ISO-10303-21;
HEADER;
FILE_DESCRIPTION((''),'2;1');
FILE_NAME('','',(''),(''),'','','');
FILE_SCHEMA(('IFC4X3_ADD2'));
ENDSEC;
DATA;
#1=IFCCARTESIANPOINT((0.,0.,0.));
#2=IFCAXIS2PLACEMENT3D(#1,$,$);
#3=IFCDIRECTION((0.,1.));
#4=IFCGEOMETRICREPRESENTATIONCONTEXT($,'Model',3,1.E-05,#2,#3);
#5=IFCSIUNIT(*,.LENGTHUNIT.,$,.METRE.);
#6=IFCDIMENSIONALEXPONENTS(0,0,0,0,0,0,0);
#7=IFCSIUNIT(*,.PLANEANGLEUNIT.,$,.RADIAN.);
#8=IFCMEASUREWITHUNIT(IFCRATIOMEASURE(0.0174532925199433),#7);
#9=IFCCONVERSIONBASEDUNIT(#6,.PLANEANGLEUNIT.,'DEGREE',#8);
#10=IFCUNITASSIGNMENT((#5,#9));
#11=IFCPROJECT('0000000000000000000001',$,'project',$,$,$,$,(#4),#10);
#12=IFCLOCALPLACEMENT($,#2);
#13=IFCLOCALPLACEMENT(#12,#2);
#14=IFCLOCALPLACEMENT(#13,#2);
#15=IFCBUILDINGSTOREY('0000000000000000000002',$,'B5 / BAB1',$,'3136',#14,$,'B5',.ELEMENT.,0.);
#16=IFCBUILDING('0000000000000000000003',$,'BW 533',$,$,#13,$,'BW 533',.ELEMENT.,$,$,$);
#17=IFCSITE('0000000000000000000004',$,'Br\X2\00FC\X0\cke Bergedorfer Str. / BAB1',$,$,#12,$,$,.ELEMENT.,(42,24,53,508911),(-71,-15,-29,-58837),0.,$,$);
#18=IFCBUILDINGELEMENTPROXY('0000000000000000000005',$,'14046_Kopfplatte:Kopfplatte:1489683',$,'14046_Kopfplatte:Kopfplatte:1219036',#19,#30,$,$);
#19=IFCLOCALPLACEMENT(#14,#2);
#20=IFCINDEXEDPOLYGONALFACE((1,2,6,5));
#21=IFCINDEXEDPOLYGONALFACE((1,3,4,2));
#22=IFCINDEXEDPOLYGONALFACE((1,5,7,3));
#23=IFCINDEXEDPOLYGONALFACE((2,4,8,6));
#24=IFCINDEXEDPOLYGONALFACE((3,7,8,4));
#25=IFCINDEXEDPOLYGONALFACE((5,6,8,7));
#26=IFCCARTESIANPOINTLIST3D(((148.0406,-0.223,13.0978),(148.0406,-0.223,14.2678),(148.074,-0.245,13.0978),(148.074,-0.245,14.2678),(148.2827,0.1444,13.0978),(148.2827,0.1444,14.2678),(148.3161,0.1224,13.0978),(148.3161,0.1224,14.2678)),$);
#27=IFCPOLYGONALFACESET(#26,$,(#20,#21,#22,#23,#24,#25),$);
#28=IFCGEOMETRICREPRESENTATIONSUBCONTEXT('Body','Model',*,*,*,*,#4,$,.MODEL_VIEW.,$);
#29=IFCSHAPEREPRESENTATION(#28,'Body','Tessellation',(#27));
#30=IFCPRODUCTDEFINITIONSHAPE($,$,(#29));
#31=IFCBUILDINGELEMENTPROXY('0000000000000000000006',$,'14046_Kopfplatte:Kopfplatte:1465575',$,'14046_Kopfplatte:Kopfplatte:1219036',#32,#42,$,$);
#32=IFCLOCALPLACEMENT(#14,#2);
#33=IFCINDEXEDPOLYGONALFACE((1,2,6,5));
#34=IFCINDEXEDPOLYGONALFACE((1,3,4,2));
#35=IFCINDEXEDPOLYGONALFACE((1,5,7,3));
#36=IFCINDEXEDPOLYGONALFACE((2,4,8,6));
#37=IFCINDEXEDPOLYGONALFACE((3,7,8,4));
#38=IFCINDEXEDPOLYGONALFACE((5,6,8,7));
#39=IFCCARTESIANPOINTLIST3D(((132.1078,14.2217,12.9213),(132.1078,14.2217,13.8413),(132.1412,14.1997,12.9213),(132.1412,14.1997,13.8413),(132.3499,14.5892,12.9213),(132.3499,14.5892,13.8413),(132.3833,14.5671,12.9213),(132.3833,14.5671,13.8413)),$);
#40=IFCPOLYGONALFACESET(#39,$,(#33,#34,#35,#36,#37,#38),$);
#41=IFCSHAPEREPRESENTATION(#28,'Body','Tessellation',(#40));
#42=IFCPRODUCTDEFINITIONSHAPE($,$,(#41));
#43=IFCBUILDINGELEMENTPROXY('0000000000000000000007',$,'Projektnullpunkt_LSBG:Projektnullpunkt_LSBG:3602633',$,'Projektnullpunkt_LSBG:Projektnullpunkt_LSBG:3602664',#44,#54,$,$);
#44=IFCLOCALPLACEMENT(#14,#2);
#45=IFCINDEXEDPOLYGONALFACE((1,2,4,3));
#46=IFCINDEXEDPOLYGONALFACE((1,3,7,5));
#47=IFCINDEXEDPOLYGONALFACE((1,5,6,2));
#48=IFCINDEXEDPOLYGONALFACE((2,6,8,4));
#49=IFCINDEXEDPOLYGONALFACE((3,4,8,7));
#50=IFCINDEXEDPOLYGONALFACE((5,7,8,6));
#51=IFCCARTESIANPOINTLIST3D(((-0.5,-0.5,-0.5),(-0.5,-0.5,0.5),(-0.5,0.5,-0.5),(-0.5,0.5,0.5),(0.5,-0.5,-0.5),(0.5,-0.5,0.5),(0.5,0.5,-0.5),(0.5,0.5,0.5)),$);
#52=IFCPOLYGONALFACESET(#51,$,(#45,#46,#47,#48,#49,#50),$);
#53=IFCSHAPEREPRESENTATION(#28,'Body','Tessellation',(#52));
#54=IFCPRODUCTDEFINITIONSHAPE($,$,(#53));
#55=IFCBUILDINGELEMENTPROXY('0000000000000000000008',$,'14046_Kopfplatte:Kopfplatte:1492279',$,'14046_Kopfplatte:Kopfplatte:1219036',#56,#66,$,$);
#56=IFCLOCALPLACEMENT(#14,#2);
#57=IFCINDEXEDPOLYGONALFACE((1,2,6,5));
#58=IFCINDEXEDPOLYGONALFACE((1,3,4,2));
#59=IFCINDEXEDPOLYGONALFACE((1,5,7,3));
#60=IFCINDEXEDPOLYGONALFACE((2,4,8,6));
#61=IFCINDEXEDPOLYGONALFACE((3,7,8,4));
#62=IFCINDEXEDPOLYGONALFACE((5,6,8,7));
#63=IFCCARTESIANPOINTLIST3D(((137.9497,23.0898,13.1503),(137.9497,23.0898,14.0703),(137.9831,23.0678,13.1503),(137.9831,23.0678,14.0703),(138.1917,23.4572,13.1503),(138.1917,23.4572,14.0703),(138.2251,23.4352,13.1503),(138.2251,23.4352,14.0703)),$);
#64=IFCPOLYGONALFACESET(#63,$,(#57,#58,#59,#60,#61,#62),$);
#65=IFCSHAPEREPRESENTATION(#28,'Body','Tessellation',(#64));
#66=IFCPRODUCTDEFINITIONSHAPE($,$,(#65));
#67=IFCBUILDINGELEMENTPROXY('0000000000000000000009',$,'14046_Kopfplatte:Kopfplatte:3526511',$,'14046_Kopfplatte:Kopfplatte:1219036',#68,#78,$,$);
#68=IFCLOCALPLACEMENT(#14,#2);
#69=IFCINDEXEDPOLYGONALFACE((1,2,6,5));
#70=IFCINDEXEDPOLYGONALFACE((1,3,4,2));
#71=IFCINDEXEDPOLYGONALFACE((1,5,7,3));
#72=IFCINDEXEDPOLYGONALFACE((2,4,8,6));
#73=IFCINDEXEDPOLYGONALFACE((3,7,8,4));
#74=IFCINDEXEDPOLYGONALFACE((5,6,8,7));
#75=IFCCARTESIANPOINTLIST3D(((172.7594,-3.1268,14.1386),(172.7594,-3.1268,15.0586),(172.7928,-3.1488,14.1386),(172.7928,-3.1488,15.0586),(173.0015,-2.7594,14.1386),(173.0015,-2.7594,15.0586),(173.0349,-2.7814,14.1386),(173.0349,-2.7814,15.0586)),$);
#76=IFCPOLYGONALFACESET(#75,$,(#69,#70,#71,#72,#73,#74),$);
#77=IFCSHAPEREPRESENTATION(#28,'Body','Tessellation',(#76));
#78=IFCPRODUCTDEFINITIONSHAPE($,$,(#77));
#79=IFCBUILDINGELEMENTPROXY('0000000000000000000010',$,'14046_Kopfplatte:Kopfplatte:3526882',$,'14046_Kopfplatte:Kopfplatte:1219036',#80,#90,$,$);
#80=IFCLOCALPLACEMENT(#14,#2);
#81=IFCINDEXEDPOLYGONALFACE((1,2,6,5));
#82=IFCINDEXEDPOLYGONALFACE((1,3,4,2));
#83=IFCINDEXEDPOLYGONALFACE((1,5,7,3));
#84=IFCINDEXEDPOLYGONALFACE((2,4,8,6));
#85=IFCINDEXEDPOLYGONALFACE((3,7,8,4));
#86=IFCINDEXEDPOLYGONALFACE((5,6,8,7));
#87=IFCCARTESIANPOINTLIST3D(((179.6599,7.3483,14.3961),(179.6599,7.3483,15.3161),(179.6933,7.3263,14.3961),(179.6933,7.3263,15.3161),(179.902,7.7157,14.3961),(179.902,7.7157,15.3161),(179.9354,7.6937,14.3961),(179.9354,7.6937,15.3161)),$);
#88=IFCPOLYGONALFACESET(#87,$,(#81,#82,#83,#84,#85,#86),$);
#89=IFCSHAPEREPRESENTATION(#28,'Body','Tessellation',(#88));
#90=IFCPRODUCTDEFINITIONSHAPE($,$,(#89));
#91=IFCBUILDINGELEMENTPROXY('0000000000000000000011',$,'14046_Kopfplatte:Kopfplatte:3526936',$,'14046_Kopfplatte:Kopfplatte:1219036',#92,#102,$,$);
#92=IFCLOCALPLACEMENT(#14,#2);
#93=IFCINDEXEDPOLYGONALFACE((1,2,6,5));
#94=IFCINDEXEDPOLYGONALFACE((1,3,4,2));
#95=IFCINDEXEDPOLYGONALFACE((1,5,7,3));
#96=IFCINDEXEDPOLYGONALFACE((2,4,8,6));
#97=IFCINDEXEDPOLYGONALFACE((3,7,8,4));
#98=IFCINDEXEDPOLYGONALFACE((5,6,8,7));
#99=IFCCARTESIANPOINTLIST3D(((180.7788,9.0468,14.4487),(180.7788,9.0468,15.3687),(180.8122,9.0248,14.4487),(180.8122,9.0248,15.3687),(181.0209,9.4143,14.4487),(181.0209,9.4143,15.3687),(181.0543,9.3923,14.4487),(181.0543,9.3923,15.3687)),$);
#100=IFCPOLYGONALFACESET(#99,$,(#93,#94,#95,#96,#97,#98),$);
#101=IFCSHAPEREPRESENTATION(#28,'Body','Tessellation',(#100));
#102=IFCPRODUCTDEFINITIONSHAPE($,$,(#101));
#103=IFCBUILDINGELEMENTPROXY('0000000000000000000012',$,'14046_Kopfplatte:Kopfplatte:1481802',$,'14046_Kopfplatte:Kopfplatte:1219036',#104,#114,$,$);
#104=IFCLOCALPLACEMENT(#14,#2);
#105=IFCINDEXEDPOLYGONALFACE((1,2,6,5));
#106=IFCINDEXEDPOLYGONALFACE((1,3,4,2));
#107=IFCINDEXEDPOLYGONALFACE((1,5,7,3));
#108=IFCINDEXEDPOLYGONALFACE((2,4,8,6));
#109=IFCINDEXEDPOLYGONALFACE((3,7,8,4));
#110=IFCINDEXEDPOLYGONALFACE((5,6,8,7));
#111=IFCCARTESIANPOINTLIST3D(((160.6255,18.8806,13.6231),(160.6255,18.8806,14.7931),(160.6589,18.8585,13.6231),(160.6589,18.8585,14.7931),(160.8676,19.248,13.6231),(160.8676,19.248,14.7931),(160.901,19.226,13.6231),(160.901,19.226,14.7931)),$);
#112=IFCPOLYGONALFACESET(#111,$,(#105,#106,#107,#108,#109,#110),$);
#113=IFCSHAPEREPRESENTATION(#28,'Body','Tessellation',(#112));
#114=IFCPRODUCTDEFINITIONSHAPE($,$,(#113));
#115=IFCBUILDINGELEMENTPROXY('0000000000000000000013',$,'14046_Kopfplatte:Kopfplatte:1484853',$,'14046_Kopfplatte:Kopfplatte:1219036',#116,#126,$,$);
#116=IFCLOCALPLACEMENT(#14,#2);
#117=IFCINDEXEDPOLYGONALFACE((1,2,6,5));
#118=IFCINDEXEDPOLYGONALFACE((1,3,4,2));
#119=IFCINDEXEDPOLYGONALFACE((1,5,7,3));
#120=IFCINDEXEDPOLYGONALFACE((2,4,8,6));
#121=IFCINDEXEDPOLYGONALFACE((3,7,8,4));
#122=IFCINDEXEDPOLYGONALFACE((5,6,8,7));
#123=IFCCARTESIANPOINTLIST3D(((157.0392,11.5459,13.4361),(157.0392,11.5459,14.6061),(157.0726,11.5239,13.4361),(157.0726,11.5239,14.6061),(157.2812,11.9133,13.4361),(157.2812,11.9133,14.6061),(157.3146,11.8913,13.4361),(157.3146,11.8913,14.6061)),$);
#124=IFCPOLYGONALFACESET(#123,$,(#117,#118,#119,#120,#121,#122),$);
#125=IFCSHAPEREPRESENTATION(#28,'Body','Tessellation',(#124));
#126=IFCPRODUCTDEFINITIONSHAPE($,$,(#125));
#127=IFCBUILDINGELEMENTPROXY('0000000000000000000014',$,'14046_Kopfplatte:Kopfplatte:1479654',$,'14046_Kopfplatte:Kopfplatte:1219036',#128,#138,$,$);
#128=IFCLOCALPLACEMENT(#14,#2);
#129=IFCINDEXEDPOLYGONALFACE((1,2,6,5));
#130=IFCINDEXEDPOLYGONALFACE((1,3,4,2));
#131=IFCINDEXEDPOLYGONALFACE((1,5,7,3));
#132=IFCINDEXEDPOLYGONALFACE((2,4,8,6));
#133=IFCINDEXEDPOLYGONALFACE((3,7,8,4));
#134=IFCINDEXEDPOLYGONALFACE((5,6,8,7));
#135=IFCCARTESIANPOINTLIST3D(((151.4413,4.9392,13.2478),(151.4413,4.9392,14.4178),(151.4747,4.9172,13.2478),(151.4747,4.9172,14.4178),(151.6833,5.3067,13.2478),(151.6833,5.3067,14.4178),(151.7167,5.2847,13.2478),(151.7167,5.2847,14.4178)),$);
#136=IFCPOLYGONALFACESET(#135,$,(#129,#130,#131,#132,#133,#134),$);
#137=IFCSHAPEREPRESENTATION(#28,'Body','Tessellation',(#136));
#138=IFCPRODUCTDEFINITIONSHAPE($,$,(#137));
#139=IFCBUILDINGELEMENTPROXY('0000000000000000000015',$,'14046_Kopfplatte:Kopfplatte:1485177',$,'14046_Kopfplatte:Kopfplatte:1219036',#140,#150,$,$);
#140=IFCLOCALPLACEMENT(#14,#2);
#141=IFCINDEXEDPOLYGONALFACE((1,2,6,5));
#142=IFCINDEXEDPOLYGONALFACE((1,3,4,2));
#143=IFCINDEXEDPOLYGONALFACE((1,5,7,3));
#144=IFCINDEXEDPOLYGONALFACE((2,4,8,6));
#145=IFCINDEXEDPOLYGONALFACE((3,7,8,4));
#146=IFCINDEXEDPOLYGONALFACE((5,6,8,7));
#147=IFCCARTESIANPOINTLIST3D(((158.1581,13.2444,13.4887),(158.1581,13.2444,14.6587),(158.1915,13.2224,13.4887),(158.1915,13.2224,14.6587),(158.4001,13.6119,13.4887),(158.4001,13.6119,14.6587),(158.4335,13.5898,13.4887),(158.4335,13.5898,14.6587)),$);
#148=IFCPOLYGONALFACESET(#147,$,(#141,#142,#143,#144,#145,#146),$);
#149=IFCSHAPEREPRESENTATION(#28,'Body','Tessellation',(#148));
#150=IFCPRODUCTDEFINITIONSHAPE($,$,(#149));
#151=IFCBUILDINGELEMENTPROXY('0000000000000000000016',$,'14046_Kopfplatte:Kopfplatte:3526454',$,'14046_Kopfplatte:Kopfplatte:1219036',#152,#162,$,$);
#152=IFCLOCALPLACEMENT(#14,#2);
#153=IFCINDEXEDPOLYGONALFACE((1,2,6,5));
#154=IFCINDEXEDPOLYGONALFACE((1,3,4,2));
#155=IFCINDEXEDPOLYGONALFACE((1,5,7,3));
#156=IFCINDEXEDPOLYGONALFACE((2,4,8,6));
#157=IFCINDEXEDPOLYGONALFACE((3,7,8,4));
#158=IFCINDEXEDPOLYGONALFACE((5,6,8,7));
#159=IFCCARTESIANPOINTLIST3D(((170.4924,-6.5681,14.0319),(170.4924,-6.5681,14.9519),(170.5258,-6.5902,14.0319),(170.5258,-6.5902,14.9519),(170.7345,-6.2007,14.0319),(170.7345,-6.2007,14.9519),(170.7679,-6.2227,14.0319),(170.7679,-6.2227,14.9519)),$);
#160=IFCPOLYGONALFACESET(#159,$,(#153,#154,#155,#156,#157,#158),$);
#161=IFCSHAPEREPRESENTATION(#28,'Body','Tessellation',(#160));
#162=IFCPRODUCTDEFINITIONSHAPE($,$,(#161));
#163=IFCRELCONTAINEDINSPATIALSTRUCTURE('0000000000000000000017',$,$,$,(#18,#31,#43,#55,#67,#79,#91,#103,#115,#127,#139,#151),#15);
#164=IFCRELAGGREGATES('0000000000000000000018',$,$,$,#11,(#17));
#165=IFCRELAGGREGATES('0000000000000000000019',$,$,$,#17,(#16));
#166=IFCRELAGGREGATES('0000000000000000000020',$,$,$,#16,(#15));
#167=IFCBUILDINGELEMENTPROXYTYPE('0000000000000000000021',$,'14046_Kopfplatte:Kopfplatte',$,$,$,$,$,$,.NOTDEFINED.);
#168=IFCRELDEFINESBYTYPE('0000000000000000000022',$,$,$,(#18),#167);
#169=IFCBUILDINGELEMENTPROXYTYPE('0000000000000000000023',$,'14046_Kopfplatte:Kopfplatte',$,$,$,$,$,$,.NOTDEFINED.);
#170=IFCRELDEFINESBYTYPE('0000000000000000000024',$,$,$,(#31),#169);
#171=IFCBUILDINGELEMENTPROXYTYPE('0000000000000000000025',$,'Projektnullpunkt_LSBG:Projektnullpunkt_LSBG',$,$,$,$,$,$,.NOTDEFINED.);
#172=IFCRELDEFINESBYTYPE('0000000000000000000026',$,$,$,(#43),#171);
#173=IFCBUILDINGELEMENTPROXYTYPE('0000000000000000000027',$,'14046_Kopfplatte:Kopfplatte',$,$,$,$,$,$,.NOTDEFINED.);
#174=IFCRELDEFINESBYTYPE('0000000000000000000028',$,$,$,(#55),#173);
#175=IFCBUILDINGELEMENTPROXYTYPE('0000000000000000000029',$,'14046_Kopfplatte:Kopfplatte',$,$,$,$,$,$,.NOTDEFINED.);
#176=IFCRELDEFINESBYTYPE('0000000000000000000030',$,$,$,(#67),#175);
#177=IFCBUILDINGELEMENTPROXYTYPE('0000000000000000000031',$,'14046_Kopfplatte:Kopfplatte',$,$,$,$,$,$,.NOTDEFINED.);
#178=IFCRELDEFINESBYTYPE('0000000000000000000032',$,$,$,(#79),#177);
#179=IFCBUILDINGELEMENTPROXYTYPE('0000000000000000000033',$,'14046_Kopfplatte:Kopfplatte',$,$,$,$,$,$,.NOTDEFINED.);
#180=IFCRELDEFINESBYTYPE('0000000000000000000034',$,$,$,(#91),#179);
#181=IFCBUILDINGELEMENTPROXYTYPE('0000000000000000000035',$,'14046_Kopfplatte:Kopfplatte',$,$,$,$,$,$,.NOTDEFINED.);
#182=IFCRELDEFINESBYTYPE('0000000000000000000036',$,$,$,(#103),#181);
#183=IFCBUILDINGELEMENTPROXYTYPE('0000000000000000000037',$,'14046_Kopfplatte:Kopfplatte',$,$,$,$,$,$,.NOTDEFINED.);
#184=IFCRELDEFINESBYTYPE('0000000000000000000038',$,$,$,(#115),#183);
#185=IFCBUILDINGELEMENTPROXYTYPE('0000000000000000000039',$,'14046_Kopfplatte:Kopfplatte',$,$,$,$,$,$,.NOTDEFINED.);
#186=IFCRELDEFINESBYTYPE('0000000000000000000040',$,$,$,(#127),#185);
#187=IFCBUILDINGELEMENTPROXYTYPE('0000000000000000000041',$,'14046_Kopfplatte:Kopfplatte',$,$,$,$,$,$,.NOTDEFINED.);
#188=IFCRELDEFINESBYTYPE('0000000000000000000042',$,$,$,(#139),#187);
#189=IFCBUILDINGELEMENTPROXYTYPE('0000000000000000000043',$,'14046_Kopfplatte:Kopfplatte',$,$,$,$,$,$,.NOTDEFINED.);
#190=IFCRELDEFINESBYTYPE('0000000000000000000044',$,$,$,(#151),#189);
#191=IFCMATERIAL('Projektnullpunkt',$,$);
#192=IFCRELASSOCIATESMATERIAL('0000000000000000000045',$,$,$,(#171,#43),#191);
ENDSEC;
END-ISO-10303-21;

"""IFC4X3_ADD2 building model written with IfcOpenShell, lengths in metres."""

from ifc_helpers import new_model, entity, si_unit, converted_unit, direction, frame, frame_2d, origin, origin_2d_with_axis, place, context, subcontext, project, spatial, rectangle, extrude, source, transform, mapped, material, type_object, type_shapes, element, save


model = new_model("IFC4X3_ADD2")

# Units and contexts
model_context = context("Model", 3, precision=1e-05, world=origin(), true_north=direction((0.0, 1.0)))
body_context = subcontext(model_context, "Body", "Model", "MODEL_VIEW")
ifc_project = project(units=[si_unit("LENGTHUNIT", "METRE"), converted_unit("PLANEANGLEUNIT", "DEGREE", entity("IfcRatioMeasure", 0.0174532925199433), si_unit("PLANEANGLEUNIT", "RADIAN"), dimensions=[0, 0, 0, 0, 0, 0, 0])], contexts=[model_context])

# Site, building, storey
site_placement = place(None, origin())
site = spatial("IfcSite", under=ifc_project, at=site_placement, Name="Brücke Bergedorfer Str. / BAB1", CompositionType="ELEMENT", RefLatitude=(42, 24, 53, 508911), RefLongitude=(-71, -15, -29, -58837), RefElevation=0.0)
building_placement = place(site_placement, origin())
building = spatial("IfcBuilding", under=site, at=building_placement, Name="BW 533", LongName="BW 533", CompositionType="ELEMENT")
storey_placement = place(building_placement, origin())
storey = spatial("IfcBuildingStorey", under=building, at=storey_placement, Name="B5 / BAB1", ObjectType="3136", LongName="B5", CompositionType="ELEMENT", Elevation=0.0)

# Building element proxies
building_element_proxy_type_1 = type_object("IfcBuildingElementProxyType", Name="14046_Kopfplatte:Kopfplatte", PredefinedType="NOTDEFINED")
shared_shape_1 = source(origin(), body_context, "Body", "SweptSolid", [
    extrude(rectangle(XDim=0.04, YDim=0.44, at=frame_2d((0.0, 0.0), x_axis=(1.0, 0.0))), frame((148.1784, -0.0503, 13.0978), z_axis=(0.0, 0.0, 1.0), x_axis=(0.835088, -0.550116, 0.0)), (0.0, 0.0, 1.0), 1.17),
])
type_shapes(building_element_proxy_type_1, [shared_shape_1])
proxy_1_placement = place(storey_placement, origin())
element("IfcBuildingElementProxy", 1, at=proxy_1_placement, inside=storey, type_object=building_element_proxy_type_1, Name="14046_Kopfplatte:Kopfplatte:1489683", ObjectType="14046_Kopfplatte:Kopfplatte:1219036", context=body_context, shape_type="MappedRepresentation", body=[
    mapped(shared_shape_1, transform((0.0, 0.0, 0.0), scale=1.0)),
])
building_element_proxy_type_2 = type_object("IfcBuildingElementProxyType", Name="14046_Kopfplatte:Kopfplatte", PredefinedType="NOTDEFINED")
shared_shape_2 = source(origin(), body_context, "Body", "SweptSolid", [
    extrude(rectangle(XDim=0.04, YDim=0.44, at=frame_2d((0.0, 0.0), x_axis=(1.0, 0.0))), frame((132.2456, 14.3944, 12.9213), z_axis=(0.0, 0.0, 1.0), x_axis=(-0.835088, 0.550116, 0.0)), (0.0, 0.0, 1.0), 0.92),
])
type_shapes(building_element_proxy_type_2, [shared_shape_2])
proxy_2_placement = place(storey_placement, origin())
element("IfcBuildingElementProxy", 2, at=proxy_2_placement, inside=storey, type_object=building_element_proxy_type_2, Name="14046_Kopfplatte:Kopfplatte:1465575", ObjectType="14046_Kopfplatte:Kopfplatte:1219036", context=body_context, shape_type="MappedRepresentation", body=[
    mapped(shared_shape_2, transform((0.0, 0.0, 0.0), scale=1.0)),
])
ifc_material_1 = material(Name="Projektnullpunkt")
building_element_proxy_type_3 = type_object("IfcBuildingElementProxyType", Name="Projektnullpunkt_LSBG:Projektnullpunkt_LSBG", PredefinedType="NOTDEFINED", material=ifc_material_1)
shared_shape_3 = source(origin(), body_context, "Body", "SweptSolid", [
    extrude(rectangle(XDim=1.0, YDim=1.0, at=origin_2d_with_axis()), frame((0.0, 0.0, -0.5), z_axis=(0.0, 0.0, 1.0), x_axis=(-1.0, 0.0, 0.0)), (0.0, 0.0, 1.0), 1.0),
])
type_shapes(building_element_proxy_type_3, [shared_shape_3])
proxy_3_placement = place(storey_placement, origin())
element("IfcBuildingElementProxy", 3, at=proxy_3_placement, inside=storey, type_object=building_element_proxy_type_3, material=ifc_material_1, Name="Projektnullpunkt_LSBG:Projektnullpunkt_LSBG:3602633", ObjectType="Projektnullpunkt_LSBG:Projektnullpunkt_LSBG:3602664", context=body_context, shape_type="MappedRepresentation", body=[
    mapped(shared_shape_3, transform((0.0, 0.0, 0.0), scale=1.0)),
])
building_element_proxy_type_4 = type_object("IfcBuildingElementProxyType", Name="14046_Kopfplatte:Kopfplatte", PredefinedType="NOTDEFINED")
shared_shape_4 = source(origin(), body_context, "Body", "SweptSolid", [
    extrude(rectangle(XDim=0.04, YDim=0.44, at=frame_2d((0.0, 0.0), x_axis=(1.0, 0.0))), frame((138.0874, 23.2625, 13.1503), z_axis=(0.0, 0.0, 1.0), x_axis=(-0.835088, 0.550116, 0.0)), (0.0, 0.0, 1.0), 0.92),
])
type_shapes(building_element_proxy_type_4, [shared_shape_4])
proxy_4_placement = place(storey_placement, origin())
element("IfcBuildingElementProxy", 4, at=proxy_4_placement, inside=storey, type_object=building_element_proxy_type_4, Name="14046_Kopfplatte:Kopfplatte:1492279", ObjectType="14046_Kopfplatte:Kopfplatte:1219036", context=body_context, shape_type="MappedRepresentation", body=[
    mapped(shared_shape_4, transform((0.0, 0.0, 0.0), scale=1.0)),
])
building_element_proxy_type_5 = type_object("IfcBuildingElementProxyType", Name="14046_Kopfplatte:Kopfplatte", PredefinedType="NOTDEFINED")
shared_shape_5 = source(origin(), body_context, "Body", "SweptSolid", [
    extrude(rectangle(XDim=0.04, YDim=0.44, at=frame_2d((0.0, 0.0), x_axis=(1.0, 0.0))), frame((172.8971, -2.9541, 14.1386), z_axis=(0.0, 0.0, 1.0), x_axis=(0.835088, -0.550116, 0.0)), (0.0, 0.0, 1.0), 0.92),
])
type_shapes(building_element_proxy_type_5, [shared_shape_5])
proxy_5_placement = place(storey_placement, origin())
element("IfcBuildingElementProxy", 5, at=proxy_5_placement, inside=storey, type_object=building_element_proxy_type_5, Name="14046_Kopfplatte:Kopfplatte:3526511", ObjectType="14046_Kopfplatte:Kopfplatte:1219036", context=body_context, shape_type="MappedRepresentation", body=[
    mapped(shared_shape_5, transform((0.0, 0.0, 0.0), scale=1.0)),
])
building_element_proxy_type_6 = type_object("IfcBuildingElementProxyType", Name="14046_Kopfplatte:Kopfplatte", PredefinedType="NOTDEFINED")
shared_shape_6 = source(origin(), body_context, "Body", "SweptSolid", [
    extrude(rectangle(XDim=0.04, YDim=0.44, at=frame_2d((0.0, 0.0), x_axis=(1.0, 0.0))), frame((179.7976, 7.521, 14.3961), z_axis=(0.0, 0.0, 1.0), x_axis=(0.835088, -0.550116, 0.0)), (0.0, 0.0, 1.0), 0.92),
])
type_shapes(building_element_proxy_type_6, [shared_shape_6])
proxy_6_placement = place(storey_placement, origin())
element("IfcBuildingElementProxy", 6, at=proxy_6_placement, inside=storey, type_object=building_element_proxy_type_6, Name="14046_Kopfplatte:Kopfplatte:3526882", ObjectType="14046_Kopfplatte:Kopfplatte:1219036", context=body_context, shape_type="MappedRepresentation", body=[
    mapped(shared_shape_6, transform((0.0, 0.0, 0.0), scale=1.0)),
])
building_element_proxy_type_7 = type_object("IfcBuildingElementProxyType", Name="14046_Kopfplatte:Kopfplatte", PredefinedType="NOTDEFINED")
shared_shape_7 = source(origin(), body_context, "Body", "SweptSolid", [
    extrude(rectangle(XDim=0.04, YDim=0.44, at=frame_2d((0.0, 0.0), x_axis=(1.0, 0.0))), frame((180.9165, 9.2195, 14.4487), z_axis=(0.0, 0.0, 1.0), x_axis=(0.835088, -0.550116, 0.0)), (0.0, 0.0, 1.0), 0.92),
])
type_shapes(building_element_proxy_type_7, [shared_shape_7])
proxy_7_placement = place(storey_placement, origin())
element("IfcBuildingElementProxy", 7, at=proxy_7_placement, inside=storey, type_object=building_element_proxy_type_7, Name="14046_Kopfplatte:Kopfplatte:3526936", ObjectType="14046_Kopfplatte:Kopfplatte:1219036", context=body_context, shape_type="MappedRepresentation", body=[
    mapped(shared_shape_7, transform((0.0, 0.0, 0.0), scale=1.0)),
])
building_element_proxy_type_8 = type_object("IfcBuildingElementProxyType", Name="14046_Kopfplatte:Kopfplatte", PredefinedType="NOTDEFINED")
shared_shape_8 = source(origin(), body_context, "Body", "SweptSolid", [
    extrude(rectangle(XDim=0.04, YDim=0.44, at=frame_2d((0.0, 0.0), x_axis=(1.0, 0.0))), frame((160.7633, 19.0533, 13.6231), z_axis=(0.0, 0.0, 1.0), x_axis=(0.835088, -0.550116, 0.0)), (0.0, 0.0, 1.0), 1.17),
])
type_shapes(building_element_proxy_type_8, [shared_shape_8])
proxy_8_placement = place(storey_placement, origin())
element("IfcBuildingElementProxy", 8, at=proxy_8_placement, inside=storey, type_object=building_element_proxy_type_8, Name="14046_Kopfplatte:Kopfplatte:1481802", ObjectType="14046_Kopfplatte:Kopfplatte:1219036", context=body_context, shape_type="MappedRepresentation", body=[
    mapped(shared_shape_8, transform((0.0, 0.0, 0.0), scale=1.0)),
])
building_element_proxy_type_9 = type_object("IfcBuildingElementProxyType", Name="14046_Kopfplatte:Kopfplatte", PredefinedType="NOTDEFINED")
shared_shape_9 = source(origin(), body_context, "Body", "SweptSolid", [
    extrude(rectangle(XDim=0.04, YDim=0.44, at=frame_2d((0.0, 0.0), x_axis=(1.0, 0.0))), frame((157.1769, 11.7186, 13.4361), z_axis=(0.0, 0.0, 1.0), x_axis=(-0.835088, 0.550116, 0.0)), (0.0, 0.0, 1.0), 1.17),
])
type_shapes(building_element_proxy_type_9, [shared_shape_9])
proxy_9_placement = place(storey_placement, origin())
element("IfcBuildingElementProxy", 9, at=proxy_9_placement, inside=storey, type_object=building_element_proxy_type_9, Name="14046_Kopfplatte:Kopfplatte:1484853", ObjectType="14046_Kopfplatte:Kopfplatte:1219036", context=body_context, shape_type="MappedRepresentation", body=[
    mapped(shared_shape_9, transform((0.0, 0.0, 0.0), scale=1.0)),
])
building_element_proxy_type_10 = type_object("IfcBuildingElementProxyType", Name="14046_Kopfplatte:Kopfplatte", PredefinedType="NOTDEFINED")
shared_shape_10 = source(origin(), body_context, "Body", "SweptSolid", [
    extrude(rectangle(XDim=0.04, YDim=0.44, at=origin_2d_with_axis()), frame((151.579, 5.112, 13.2478), z_axis=(0.0, 0.0, 1.0), x_axis=(0.835088, -0.550116, 0.0)), (0.0, 0.0, 1.0), 1.17),
])
type_shapes(building_element_proxy_type_10, [shared_shape_10])
proxy_10_placement = place(storey_placement, origin())
element("IfcBuildingElementProxy", 10, at=proxy_10_placement, inside=storey, type_object=building_element_proxy_type_10, Name="14046_Kopfplatte:Kopfplatte:1479654", ObjectType="14046_Kopfplatte:Kopfplatte:1219036", context=body_context, shape_type="MappedRepresentation", body=[
    mapped(shared_shape_10, transform((0.0, 0.0, 0.0), scale=1.0)),
])
building_element_proxy_type_11 = type_object("IfcBuildingElementProxyType", Name="14046_Kopfplatte:Kopfplatte", PredefinedType="NOTDEFINED")
shared_shape_11 = source(origin(), body_context, "Body", "SweptSolid", [
    extrude(rectangle(XDim=0.04, YDim=0.44, at=frame_2d((0.0, 0.0), x_axis=(1.0, 0.0))), frame((158.2958, 13.4171, 13.4887), z_axis=(0.0, 0.0, 1.0), x_axis=(-0.835088, 0.550116, 0.0)), (0.0, 0.0, 1.0), 1.17),
])
type_shapes(building_element_proxy_type_11, [shared_shape_11])
proxy_11_placement = place(storey_placement, origin())
element("IfcBuildingElementProxy", 11, at=proxy_11_placement, inside=storey, type_object=building_element_proxy_type_11, Name="14046_Kopfplatte:Kopfplatte:1485177", ObjectType="14046_Kopfplatte:Kopfplatte:1219036", context=body_context, shape_type="MappedRepresentation", body=[
    mapped(shared_shape_11, transform((0.0, 0.0, 0.0), scale=1.0)),
])
building_element_proxy_type_12 = type_object("IfcBuildingElementProxyType", Name="14046_Kopfplatte:Kopfplatte", PredefinedType="NOTDEFINED")
shared_shape_12 = source(origin(), body_context, "Body", "SweptSolid", [
    extrude(rectangle(XDim=0.04, YDim=0.44, at=frame_2d((0.0, 0.0), x_axis=(1.0, 0.0))), frame((170.6301, -6.3954, 14.0319), z_axis=(0.0, 0.0, 1.0), x_axis=(0.835088, -0.550116, 0.0)), (0.0, 0.0, 1.0), 0.92),
])
type_shapes(building_element_proxy_type_12, [shared_shape_12])
proxy_12_placement = place(storey_placement, origin())
element("IfcBuildingElementProxy", 12, at=proxy_12_placement, inside=storey, type_object=building_element_proxy_type_12, Name="14046_Kopfplatte:Kopfplatte:3526454", ObjectType="14046_Kopfplatte:Kopfplatte:1219036", context=body_context, shape_type="MappedRepresentation", body=[
    mapped(shared_shape_12, transform((0.0, 0.0, 0.0), scale=1.0)),
])

save(model, "model.ifc")
